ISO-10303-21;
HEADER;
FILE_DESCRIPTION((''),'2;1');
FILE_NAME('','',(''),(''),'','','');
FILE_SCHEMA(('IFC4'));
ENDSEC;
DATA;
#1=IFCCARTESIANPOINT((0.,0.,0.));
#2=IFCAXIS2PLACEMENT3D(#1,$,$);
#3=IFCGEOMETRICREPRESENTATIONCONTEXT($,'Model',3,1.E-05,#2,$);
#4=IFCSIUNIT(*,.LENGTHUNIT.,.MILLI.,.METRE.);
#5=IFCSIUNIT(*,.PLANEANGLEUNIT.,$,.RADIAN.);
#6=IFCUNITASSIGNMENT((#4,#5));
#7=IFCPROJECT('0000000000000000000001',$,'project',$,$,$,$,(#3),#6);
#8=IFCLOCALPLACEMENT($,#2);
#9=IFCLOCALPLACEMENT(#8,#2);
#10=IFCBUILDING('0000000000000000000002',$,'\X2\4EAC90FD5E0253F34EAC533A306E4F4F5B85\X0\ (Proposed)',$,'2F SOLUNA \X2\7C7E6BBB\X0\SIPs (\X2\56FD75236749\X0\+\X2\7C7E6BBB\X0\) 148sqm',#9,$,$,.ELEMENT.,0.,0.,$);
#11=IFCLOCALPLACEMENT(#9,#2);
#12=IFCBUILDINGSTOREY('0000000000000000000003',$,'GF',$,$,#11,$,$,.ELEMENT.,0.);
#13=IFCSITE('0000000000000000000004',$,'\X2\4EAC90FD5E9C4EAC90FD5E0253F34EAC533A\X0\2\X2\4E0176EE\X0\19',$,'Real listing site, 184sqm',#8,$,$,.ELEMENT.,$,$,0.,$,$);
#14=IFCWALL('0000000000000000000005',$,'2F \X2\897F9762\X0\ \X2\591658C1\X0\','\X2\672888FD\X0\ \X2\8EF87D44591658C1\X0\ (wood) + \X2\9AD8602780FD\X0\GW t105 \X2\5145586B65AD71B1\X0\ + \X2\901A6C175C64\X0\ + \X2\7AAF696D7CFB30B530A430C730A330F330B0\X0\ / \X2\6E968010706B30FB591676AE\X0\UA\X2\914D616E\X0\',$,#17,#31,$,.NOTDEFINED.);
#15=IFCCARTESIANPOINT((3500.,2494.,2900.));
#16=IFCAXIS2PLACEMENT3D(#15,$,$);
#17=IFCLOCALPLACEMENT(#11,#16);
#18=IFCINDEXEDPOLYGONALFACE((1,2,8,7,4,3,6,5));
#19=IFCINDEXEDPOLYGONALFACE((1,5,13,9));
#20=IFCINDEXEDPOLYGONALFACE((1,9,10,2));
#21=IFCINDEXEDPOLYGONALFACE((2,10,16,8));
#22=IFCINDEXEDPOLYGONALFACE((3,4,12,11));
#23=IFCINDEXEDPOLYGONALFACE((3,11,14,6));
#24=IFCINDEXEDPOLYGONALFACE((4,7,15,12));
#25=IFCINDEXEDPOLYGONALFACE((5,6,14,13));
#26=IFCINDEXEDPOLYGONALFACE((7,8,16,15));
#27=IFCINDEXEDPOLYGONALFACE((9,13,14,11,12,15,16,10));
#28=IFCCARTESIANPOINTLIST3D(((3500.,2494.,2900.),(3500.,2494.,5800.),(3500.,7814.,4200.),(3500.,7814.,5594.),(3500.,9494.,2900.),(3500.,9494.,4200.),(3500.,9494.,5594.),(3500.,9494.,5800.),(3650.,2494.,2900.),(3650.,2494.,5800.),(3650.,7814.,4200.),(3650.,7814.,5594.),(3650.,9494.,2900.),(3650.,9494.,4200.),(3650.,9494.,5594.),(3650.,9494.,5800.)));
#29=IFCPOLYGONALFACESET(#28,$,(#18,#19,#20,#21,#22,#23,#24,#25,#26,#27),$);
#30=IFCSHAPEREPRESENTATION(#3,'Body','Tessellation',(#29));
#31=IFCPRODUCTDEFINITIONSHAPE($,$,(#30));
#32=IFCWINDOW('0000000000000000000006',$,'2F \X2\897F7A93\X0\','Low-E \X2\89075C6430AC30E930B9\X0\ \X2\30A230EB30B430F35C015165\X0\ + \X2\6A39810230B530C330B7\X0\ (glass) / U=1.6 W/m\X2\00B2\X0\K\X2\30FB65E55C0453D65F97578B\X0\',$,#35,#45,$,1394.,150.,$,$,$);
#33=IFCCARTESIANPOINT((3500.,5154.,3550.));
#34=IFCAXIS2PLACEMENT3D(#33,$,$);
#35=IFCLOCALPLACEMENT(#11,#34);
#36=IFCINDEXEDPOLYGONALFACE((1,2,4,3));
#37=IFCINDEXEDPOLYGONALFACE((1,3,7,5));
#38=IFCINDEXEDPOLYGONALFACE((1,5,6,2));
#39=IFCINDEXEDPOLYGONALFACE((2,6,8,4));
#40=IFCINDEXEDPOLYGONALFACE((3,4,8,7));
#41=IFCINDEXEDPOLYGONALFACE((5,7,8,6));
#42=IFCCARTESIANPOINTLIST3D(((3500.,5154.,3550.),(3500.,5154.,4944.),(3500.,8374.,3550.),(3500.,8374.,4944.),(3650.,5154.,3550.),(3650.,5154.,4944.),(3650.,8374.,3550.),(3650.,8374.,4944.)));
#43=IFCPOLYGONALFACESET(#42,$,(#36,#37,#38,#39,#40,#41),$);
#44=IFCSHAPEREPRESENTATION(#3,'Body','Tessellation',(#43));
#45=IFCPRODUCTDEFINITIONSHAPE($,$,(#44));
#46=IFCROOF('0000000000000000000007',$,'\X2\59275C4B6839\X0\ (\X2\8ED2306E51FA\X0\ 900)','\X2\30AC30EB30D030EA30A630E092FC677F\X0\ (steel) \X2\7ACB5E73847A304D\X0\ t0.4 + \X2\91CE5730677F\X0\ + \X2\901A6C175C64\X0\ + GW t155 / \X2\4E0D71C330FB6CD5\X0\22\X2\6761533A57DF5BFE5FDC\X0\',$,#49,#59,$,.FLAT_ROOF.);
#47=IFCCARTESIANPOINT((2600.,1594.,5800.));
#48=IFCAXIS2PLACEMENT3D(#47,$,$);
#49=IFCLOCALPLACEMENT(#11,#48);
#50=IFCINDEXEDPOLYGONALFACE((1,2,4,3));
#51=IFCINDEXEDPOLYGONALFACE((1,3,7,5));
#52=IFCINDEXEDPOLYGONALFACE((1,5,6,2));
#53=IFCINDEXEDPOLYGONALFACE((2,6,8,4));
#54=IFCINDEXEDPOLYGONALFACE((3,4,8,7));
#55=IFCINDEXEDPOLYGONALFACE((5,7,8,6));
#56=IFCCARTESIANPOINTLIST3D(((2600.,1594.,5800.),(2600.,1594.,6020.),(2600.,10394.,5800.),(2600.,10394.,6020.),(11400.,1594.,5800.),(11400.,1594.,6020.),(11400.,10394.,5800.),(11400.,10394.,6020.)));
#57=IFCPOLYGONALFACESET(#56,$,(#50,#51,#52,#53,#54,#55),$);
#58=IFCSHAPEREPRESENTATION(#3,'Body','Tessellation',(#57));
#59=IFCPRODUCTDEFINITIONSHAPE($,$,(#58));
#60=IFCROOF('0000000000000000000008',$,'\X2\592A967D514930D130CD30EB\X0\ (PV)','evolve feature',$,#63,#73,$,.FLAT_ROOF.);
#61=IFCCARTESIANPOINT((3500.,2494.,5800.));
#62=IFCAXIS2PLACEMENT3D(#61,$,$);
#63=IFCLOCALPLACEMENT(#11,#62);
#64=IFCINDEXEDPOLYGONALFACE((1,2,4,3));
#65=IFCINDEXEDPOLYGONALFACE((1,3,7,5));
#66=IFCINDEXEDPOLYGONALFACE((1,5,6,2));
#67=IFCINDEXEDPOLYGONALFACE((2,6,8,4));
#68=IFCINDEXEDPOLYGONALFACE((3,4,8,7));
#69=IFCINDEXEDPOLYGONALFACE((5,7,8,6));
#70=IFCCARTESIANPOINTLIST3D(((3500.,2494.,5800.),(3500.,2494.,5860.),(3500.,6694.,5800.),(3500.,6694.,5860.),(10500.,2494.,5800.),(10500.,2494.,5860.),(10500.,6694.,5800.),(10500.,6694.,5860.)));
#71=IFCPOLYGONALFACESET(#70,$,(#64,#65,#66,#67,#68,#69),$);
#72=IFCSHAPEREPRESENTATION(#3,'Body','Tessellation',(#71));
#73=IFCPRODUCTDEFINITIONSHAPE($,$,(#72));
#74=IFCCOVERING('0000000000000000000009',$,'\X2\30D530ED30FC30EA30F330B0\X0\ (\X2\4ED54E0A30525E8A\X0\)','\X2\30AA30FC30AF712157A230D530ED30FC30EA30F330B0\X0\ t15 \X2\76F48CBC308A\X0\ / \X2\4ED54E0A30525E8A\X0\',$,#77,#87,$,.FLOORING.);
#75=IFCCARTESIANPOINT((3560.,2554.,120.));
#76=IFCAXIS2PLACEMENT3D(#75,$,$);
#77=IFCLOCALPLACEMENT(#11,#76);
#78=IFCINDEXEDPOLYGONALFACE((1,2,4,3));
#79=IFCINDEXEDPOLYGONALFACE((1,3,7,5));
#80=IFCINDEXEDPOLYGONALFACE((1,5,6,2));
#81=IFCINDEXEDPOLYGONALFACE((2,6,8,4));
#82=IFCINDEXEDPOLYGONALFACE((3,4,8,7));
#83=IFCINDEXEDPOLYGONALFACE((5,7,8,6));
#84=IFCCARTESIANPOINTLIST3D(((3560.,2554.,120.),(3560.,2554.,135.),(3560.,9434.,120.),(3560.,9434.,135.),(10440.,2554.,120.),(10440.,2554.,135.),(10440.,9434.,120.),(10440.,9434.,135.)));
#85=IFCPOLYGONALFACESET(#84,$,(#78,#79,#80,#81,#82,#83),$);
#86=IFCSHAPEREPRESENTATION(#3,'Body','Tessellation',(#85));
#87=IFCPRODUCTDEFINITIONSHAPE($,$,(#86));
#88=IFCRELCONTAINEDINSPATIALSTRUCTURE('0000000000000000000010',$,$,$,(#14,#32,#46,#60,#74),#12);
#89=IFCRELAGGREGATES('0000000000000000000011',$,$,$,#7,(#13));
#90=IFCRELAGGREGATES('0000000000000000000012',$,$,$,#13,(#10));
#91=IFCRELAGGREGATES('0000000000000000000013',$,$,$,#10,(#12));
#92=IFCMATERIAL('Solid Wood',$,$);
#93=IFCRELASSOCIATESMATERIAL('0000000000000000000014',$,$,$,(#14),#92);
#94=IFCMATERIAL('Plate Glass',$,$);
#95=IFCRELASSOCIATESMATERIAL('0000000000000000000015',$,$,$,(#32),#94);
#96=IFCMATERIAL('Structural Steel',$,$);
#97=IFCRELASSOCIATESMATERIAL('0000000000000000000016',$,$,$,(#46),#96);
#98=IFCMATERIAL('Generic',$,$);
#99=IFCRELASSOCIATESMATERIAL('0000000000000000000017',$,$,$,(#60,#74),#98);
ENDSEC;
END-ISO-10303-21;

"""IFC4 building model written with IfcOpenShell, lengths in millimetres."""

from ifc_helpers import new_model, si_unit, frame, frame_2d, origin, place, context, project, spatial, rectangle, extrude, material, element, fill, save


model = new_model("IFC4")

# Units and contexts
model_context = context("Model", 3, precision=1e-05, world=origin())
ifc_project = project(units=[si_unit("LENGTHUNIT", "METRE", prefix="MILLI"), si_unit("PLANEANGLEUNIT", "RADIAN")], contexts=[model_context])

# Site, building, storey
site_placement = place(None, origin())
site = spatial("IfcSite", under=ifc_project, at=site_placement, Name="京都府京都市右京区2丁目19", ObjectType="Real listing site, 184sqm", CompositionType="ELEMENT", RefElevation=0.0)
building_placement = place(site_placement, origin())
building = spatial("IfcBuilding", under=site, at=building_placement, Name="京都市右京区の住宅 (Proposed)", ObjectType="2F SOLUNA 籾殻SIPs (国産杉+籾殻) 148sqm", CompositionType="ELEMENT", ElevationOfRefHeight=0.0, ElevationOfTerrain=0.0)
storey_placement = place(building_placement, origin())
storey = spatial("IfcBuildingStorey", under=building, at=storey_placement, Name="GF", CompositionType="ELEMENT", Elevation=0.0)

# Shared definitions
ifc_material_1 = material(Name="Solid Wood")
ifc_material_2 = material(Name="Generic")

# Shared definitions
ifc_material_3 = material(Name="Plate Glass")

# Wall, opening, window
wall_1_placement = place(storey_placement, frame((3500.0, 2494.0, 2900.0)))
wall_1 = element("IfcWall", 1, at=wall_1_placement, inside=storey, material=ifc_material_1, Name="2F 西面 外壁", Description="木製 軸組外壁 (wood) + 高性能GW t105 充填断熱 + 通気層 + 窯業系サイディング / 準耐火・外皮UA配慮", PredefinedType="NOTDEFINED", context=model_context, shape_type="SweptSolid", body=[
    extrude(rectangle(XDim=150.0, YDim=7000.0, at=frame_2d((75.0, 3500.0))), frame((3500.0, 2494.0, 2900.0)), (0.0, 0.0, 1.0), 2900.0),
])
opening_1_placement = place(storey_placement, frame((3500.0, 5154.0, 3550.0)))
opening_1 = element("IfcOpeningElement", 2, at=opening_1_placement, cuts=wall_1, PredefinedType="NOTDEFINED", context=model_context, shape_type="SweptSolid", body=[
    extrude(rectangle(XDim=150.0, YDim=3220.0, at=frame_2d((75.0, 1610.0))), frame((3500.0, 5154.0, 3550.0)), (0.0, 0.0, 1.0), 1394.0),
])
window_1_placement = place(storey_placement, frame((3500.0, 5154.0, 3550.0)))
window_1 = element("IfcWindow", 3, at=window_1_placement, inside=storey, material=ifc_material_3, Name="2F 西窓", Description="Low-E 複層ガラス アルゴン封入 + 樹脂サッシ (glass) / U=1.6 W/m²K・日射取得型", OverallHeight=1394.0, OverallWidth=150.0, context=model_context, shape_type="SweptSolid", body=[
    extrude(rectangle(XDim=150.0, YDim=3220.0, at=frame_2d((75.0, 1610.0))), frame((3500.0, 5154.0, 3550.0)), (0.0, 0.0, 1.0), 1394.0),
])
fill(opening_1, window_1)

# Roofs
ifc_material_4 = material(Name="Structural Steel")
roof_1_placement = place(storey_placement, frame((2600.0, 1594.0, 5800.0)))
element("IfcRoof", 4, at=roof_1_placement, inside=storey, material=ifc_material_4, Name="大屋根 (軒の出 900)", Description="ガルバリウム鋼板 (steel) 立平葺き t0.4 + 野地板 + 通気層 + GW t155 / 不燃・法22条区域対応", PredefinedType="FLAT_ROOF", context=model_context, shape_type="SweptSolid", body=[
    extrude(rectangle(XDim=8800.0, YDim=8800.0, at=frame_2d((4400.0, 4400.0))), frame((2600.0, 1594.0, 5800.0)), (0.0, 0.0, 1.0), 220.0),
])
roof_2_placement = place(storey_placement, frame((3500.0, 2494.0, 5800.0)))
element("IfcRoof", 5, at=roof_2_placement, inside=storey, material=ifc_material_2, Name="太陽光パネル (PV)", Description="evolve feature", PredefinedType="FLAT_ROOF", context=model_context, shape_type="SweptSolid", body=[
    extrude(rectangle(XDim=7000.0, YDim=4200.0, at=frame_2d((3500.0, 2100.0))), frame((3500.0, 2494.0, 5800.0)), (0.0, 0.0, 1.0), 60.0),
])

# Covering
covering_placement = place(storey_placement, frame((3560.0, 2554.0, 120.0)))
element("IfcCovering", 6, at=covering_placement, inside=storey, material=ifc_material_2, Name="フローリング (仕上げ床)", Description="オーク無垢フローリング t15 直貼り / 仕上げ床", PredefinedType="FLOORING", context=model_context, shape_type="SweptSolid", body=[
    extrude(rectangle(XDim=6880.0, YDim=6880.0, at=frame_2d((3440.0, 3440.0))), frame((3560.0, 2554.0, 120.0)), (0.0, 0.0, 1.0), 15.0),
])

save(model, "model.ifc")
